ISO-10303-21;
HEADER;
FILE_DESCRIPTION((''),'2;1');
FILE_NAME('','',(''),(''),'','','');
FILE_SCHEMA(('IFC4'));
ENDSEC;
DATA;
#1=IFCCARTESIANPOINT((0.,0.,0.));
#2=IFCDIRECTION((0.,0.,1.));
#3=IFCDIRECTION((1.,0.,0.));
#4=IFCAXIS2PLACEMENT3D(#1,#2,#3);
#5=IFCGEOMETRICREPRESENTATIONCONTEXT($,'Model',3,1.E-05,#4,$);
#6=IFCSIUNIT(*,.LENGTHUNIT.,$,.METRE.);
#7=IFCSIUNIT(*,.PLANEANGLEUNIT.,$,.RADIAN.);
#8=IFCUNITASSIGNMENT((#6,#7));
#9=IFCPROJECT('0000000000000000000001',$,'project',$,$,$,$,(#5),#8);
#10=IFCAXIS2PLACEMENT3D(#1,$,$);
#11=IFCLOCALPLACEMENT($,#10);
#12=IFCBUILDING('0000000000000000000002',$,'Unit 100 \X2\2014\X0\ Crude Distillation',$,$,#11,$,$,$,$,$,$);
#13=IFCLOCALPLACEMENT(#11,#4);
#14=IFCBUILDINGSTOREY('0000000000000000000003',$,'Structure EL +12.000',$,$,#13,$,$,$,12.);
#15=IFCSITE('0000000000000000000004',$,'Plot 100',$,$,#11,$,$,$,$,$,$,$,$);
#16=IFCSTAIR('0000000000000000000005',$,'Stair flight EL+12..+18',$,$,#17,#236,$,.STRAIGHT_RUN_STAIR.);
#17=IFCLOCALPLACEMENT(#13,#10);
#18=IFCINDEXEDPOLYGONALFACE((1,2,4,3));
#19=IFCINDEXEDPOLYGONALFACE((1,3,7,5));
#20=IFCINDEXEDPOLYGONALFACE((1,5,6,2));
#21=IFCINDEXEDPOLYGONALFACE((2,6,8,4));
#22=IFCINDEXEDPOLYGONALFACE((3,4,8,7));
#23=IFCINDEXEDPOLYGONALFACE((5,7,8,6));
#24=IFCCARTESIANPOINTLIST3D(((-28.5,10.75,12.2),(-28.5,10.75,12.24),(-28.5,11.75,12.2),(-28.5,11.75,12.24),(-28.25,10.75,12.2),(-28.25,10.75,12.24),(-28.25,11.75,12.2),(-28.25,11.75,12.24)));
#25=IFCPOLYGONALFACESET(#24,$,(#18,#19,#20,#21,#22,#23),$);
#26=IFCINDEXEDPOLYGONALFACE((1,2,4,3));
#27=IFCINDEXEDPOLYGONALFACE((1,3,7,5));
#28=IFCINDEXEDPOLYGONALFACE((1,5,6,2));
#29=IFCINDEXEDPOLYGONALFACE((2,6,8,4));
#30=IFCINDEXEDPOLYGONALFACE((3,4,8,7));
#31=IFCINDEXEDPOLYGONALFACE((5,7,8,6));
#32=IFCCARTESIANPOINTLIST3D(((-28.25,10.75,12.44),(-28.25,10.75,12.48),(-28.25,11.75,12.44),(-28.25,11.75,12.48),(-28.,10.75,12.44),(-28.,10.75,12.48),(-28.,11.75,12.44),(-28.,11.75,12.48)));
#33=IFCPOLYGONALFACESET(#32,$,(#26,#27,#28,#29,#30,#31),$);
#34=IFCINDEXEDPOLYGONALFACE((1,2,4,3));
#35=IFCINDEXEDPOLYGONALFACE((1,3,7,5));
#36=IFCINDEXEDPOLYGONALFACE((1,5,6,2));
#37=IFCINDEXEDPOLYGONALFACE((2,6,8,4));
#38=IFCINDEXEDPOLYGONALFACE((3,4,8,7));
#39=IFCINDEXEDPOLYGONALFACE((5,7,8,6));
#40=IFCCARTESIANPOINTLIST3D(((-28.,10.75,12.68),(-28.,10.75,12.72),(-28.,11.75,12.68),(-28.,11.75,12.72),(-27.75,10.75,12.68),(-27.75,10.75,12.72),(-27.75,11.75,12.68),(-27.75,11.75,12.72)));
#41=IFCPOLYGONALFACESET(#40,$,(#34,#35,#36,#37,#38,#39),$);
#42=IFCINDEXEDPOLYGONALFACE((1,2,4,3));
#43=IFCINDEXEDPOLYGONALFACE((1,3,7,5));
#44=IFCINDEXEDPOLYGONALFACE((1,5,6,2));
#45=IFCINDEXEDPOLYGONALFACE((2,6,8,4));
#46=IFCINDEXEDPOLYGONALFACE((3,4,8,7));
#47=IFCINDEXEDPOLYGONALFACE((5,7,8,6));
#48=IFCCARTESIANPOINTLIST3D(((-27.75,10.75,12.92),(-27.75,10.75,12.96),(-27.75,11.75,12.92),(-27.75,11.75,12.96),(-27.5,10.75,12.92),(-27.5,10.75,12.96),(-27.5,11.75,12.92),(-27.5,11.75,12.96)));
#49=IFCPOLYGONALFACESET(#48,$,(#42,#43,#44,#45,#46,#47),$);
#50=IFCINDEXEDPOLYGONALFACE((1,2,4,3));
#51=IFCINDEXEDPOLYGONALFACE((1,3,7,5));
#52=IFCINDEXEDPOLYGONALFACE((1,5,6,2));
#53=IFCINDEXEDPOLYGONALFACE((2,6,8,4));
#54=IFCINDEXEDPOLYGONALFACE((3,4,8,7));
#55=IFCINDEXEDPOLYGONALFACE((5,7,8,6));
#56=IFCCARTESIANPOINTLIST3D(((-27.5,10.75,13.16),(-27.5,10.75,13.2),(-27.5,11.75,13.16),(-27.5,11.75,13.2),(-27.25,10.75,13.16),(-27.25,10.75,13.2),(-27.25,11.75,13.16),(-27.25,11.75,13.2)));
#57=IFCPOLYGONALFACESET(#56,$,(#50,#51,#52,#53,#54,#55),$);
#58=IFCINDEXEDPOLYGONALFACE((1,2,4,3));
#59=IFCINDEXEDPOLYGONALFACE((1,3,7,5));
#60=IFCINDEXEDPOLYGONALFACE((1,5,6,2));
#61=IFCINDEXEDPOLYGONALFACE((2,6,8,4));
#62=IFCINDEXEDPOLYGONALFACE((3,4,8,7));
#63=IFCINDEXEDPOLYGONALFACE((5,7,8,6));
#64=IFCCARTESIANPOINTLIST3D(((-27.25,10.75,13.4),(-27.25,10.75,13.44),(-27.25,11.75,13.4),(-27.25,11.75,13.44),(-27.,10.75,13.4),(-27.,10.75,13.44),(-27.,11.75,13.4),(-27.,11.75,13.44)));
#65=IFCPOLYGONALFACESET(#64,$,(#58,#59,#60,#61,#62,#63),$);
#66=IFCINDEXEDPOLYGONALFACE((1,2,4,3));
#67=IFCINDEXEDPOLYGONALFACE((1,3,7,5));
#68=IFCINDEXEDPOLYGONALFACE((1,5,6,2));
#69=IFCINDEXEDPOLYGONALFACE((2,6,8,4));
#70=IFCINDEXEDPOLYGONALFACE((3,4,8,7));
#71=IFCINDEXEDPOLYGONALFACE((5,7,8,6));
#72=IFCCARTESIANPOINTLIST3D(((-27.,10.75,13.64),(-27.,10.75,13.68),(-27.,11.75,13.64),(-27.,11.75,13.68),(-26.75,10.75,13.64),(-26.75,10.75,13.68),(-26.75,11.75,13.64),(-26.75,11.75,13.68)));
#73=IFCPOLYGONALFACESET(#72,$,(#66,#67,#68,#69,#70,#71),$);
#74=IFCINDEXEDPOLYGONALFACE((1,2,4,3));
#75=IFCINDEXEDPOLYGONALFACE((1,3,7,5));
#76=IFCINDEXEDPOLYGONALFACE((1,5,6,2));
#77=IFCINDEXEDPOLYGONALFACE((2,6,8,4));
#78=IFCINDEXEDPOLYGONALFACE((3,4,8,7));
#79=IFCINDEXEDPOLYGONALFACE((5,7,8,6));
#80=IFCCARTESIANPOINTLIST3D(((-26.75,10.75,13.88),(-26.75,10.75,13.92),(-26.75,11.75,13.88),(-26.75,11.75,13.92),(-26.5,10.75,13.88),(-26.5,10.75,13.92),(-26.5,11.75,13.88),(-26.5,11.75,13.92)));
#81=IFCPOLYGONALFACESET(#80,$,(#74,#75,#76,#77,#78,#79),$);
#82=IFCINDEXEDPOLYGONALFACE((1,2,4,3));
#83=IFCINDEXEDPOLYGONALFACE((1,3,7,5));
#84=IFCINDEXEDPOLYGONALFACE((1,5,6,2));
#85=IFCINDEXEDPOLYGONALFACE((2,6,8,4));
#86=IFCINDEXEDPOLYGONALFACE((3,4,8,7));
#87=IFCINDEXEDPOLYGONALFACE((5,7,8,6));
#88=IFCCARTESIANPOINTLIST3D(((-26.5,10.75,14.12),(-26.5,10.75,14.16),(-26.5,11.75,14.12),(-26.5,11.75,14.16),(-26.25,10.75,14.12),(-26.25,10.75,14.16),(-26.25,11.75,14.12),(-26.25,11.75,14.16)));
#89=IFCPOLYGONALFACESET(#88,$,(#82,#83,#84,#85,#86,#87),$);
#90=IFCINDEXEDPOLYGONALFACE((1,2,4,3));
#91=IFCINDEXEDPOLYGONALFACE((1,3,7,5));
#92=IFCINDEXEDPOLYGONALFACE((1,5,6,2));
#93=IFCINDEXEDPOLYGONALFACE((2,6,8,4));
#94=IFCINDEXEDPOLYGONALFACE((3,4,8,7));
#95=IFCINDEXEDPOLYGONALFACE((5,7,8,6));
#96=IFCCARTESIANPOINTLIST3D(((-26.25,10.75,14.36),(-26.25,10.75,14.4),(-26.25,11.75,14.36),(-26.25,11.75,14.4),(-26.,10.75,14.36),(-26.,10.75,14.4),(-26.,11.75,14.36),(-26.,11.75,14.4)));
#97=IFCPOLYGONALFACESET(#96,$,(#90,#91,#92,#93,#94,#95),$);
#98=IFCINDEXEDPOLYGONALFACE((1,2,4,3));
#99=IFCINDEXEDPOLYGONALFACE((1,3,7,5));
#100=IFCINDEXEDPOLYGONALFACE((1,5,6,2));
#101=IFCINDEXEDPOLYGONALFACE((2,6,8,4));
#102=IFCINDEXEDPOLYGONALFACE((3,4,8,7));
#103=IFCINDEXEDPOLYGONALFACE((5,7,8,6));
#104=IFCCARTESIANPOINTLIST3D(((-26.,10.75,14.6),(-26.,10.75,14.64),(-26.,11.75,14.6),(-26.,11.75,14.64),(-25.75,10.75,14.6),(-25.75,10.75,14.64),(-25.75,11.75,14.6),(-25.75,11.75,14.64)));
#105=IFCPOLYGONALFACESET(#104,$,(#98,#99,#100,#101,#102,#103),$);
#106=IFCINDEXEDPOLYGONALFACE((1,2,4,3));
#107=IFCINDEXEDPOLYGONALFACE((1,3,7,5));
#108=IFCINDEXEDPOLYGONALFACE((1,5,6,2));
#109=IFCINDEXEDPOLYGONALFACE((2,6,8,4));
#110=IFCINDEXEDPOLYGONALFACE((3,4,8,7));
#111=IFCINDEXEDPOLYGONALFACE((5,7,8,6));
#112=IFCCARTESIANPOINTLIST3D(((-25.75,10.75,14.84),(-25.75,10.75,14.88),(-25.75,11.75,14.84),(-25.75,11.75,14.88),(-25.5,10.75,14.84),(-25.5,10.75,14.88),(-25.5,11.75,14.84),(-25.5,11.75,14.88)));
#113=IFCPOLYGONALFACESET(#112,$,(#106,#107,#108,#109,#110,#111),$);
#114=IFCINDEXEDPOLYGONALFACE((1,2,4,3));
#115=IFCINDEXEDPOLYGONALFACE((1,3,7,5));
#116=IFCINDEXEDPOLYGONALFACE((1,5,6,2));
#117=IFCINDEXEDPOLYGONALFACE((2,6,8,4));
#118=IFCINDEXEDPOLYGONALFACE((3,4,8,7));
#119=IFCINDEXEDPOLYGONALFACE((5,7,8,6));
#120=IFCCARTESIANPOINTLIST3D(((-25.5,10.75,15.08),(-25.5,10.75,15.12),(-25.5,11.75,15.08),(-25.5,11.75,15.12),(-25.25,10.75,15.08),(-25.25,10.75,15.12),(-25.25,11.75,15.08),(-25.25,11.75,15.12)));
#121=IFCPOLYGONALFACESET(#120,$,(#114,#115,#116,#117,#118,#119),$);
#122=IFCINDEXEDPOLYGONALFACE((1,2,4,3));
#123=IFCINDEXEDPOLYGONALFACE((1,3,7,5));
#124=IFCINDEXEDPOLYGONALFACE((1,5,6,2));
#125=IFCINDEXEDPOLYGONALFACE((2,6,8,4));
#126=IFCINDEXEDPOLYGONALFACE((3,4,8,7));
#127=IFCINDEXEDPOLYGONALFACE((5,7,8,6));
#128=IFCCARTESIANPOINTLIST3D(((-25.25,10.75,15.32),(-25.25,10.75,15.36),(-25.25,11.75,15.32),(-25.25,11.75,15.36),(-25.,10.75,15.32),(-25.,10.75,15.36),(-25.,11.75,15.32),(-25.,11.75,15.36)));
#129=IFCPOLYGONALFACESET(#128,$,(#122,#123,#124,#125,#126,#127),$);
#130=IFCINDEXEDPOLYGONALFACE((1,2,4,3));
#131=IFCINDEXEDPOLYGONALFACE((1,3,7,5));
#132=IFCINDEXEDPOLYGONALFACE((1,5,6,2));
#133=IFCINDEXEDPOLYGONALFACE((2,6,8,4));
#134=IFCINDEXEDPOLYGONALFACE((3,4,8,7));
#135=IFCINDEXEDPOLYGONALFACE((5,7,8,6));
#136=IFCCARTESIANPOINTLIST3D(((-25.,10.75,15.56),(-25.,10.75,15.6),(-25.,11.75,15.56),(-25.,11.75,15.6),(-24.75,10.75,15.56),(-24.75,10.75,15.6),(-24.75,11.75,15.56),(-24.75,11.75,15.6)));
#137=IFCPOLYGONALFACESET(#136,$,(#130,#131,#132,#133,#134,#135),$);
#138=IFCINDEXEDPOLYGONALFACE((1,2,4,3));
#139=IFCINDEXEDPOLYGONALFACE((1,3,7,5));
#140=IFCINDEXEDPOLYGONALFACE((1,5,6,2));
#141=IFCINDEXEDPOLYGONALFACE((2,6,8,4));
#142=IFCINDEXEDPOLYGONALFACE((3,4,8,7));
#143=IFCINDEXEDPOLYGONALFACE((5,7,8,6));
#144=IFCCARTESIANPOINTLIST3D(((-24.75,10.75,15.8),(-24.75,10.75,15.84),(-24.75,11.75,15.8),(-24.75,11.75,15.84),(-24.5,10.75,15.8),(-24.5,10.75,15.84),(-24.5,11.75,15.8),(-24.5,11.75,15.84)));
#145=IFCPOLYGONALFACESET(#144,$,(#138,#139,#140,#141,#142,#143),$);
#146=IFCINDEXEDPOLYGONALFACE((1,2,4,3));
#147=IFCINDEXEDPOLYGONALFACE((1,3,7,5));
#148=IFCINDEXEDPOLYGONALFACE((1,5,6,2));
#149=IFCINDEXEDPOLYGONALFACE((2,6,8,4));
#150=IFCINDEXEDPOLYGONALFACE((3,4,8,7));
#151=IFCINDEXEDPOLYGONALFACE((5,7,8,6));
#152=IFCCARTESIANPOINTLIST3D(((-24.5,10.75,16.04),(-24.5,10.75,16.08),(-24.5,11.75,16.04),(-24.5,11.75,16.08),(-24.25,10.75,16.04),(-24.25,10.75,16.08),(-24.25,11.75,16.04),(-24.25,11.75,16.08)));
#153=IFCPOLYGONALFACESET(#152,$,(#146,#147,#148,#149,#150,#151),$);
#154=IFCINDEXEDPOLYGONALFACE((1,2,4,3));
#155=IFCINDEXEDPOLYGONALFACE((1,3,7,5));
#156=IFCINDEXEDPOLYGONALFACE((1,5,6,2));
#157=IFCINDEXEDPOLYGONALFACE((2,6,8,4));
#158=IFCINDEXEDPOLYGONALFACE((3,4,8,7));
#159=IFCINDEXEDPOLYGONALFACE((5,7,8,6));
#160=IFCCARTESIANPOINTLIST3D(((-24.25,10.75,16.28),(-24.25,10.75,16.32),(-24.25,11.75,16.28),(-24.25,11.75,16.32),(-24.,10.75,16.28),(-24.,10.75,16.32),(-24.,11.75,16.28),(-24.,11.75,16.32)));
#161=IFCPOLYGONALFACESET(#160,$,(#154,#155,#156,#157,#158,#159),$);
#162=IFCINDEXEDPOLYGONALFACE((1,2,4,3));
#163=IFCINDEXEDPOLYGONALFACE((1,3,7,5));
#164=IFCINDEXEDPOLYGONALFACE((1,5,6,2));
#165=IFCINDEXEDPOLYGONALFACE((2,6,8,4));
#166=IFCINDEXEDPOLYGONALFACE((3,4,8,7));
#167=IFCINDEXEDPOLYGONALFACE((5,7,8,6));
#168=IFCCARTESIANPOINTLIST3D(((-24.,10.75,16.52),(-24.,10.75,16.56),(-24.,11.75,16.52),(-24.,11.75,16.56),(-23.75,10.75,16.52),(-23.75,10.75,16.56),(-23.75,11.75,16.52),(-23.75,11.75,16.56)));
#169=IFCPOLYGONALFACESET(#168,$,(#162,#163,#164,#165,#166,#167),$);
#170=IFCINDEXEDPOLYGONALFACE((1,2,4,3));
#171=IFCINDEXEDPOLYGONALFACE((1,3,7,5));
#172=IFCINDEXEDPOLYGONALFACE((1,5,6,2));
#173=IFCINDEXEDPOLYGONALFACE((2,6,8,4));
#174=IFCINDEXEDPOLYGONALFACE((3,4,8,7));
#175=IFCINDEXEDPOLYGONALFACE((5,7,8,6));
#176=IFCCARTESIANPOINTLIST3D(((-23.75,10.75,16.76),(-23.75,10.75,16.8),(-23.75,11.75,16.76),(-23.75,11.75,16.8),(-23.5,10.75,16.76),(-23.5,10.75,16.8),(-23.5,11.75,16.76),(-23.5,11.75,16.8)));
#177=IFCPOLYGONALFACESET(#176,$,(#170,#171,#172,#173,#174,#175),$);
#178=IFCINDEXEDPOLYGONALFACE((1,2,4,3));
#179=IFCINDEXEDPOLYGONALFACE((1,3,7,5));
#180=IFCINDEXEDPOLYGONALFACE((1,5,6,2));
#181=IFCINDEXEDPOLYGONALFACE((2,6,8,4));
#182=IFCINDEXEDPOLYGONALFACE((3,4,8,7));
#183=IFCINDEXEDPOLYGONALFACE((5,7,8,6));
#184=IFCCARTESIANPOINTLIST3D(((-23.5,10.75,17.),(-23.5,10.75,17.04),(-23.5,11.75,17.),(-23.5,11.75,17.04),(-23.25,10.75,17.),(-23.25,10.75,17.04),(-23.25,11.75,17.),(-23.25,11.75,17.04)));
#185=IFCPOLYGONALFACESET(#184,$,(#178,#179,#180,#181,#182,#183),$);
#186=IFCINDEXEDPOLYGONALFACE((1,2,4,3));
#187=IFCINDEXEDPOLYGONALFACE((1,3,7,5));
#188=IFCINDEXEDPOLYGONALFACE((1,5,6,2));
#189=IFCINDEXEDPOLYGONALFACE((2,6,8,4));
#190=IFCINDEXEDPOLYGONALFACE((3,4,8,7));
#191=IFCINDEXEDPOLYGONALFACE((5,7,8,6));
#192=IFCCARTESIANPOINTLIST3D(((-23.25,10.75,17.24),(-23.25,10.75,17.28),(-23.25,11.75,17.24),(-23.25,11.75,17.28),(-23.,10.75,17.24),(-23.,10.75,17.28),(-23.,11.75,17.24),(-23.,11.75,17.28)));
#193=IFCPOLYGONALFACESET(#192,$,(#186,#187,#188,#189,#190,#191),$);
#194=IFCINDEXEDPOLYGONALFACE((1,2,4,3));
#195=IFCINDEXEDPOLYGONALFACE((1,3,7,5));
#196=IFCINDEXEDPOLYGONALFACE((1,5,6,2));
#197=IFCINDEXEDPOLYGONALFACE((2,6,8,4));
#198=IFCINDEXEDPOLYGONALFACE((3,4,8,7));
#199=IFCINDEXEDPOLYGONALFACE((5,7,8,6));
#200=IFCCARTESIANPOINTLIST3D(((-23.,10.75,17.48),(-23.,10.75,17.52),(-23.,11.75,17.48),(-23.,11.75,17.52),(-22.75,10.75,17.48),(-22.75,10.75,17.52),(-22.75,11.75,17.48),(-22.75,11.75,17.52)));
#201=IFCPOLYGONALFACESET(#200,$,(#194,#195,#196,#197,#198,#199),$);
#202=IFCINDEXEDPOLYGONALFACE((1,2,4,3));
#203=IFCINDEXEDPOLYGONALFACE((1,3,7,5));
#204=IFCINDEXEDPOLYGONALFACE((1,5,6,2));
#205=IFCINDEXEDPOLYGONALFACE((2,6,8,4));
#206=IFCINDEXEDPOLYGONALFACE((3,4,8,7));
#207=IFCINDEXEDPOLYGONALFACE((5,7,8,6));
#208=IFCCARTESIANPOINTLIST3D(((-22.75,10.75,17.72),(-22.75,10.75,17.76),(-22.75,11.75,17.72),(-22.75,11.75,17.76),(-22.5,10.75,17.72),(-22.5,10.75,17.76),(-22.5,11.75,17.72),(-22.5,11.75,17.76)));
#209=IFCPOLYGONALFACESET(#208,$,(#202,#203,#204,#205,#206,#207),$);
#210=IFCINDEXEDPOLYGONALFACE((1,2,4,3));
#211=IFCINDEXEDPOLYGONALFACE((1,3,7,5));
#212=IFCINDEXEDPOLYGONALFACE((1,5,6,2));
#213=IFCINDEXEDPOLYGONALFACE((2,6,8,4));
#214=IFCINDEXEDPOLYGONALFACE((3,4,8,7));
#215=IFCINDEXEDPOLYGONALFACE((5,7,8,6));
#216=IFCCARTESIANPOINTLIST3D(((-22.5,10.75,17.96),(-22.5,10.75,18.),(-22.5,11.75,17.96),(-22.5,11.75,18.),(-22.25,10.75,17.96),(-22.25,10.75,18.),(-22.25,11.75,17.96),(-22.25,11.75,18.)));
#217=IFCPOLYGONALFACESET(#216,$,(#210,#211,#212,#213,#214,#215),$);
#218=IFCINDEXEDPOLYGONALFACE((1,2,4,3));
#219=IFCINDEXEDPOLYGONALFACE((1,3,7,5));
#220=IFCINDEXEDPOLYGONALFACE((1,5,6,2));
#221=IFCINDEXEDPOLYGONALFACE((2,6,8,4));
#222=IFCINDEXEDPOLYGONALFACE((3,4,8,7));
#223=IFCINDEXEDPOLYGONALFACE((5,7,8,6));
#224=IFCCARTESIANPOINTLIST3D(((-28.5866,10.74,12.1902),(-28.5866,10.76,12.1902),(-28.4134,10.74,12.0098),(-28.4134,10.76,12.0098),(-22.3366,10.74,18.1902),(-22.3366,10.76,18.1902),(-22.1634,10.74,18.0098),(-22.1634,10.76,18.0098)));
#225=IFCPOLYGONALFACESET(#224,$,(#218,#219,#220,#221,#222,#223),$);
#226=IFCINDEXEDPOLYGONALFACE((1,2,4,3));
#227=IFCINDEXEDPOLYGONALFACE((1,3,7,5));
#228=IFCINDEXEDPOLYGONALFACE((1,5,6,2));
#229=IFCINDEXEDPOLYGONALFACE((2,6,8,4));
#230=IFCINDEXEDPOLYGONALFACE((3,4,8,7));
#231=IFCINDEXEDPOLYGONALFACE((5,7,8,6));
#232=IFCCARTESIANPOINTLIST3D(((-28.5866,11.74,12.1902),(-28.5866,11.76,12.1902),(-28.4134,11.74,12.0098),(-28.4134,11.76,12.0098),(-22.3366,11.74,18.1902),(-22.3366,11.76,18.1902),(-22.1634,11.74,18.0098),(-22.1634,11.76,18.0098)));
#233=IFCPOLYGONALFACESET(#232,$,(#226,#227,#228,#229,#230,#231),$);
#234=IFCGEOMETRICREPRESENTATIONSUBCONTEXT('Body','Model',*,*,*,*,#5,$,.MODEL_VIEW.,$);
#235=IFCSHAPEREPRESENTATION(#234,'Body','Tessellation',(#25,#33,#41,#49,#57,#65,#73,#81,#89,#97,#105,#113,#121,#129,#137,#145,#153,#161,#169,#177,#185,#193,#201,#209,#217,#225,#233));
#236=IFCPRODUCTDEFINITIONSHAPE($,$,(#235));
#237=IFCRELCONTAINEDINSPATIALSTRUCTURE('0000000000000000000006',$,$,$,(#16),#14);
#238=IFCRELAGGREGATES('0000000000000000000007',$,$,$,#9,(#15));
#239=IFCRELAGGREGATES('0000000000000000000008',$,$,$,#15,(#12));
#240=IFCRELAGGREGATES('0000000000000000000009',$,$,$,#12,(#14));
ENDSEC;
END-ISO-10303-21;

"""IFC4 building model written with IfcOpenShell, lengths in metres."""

from ifc_helpers import new_model, si_unit, frame, origin, origin_with_axes, origin_2d, place, context, subcontext, project, spatial, rectangle, extrude, element, save


model = new_model("IFC4")

# Units and contexts
model_context = context("Model", 3, precision=1e-05, world=origin_with_axes())
body_context = subcontext(model_context, "Body", "Model", "MODEL_VIEW")
ifc_project = project(units=[si_unit("LENGTHUNIT", "METRE"), si_unit("PLANEANGLEUNIT", "RADIAN")], contexts=[model_context])

# Site, building, storey
placement = place(None, origin())
site = spatial("IfcSite", under=ifc_project, at=placement, Name="Plot 100")
building = spatial("IfcBuilding", under=site, at=placement, Name="Unit 100 — Crude Distillation")
storey_placement = place(placement, origin_with_axes())
storey = spatial("IfcBuildingStorey", under=building, at=storey_placement, Name="Structure EL +12.000", Elevation=12.0)

# Stair
stair_placement = place(storey_placement, origin_with_axes())
element("IfcStair", 1, at=stair_placement, inside=storey, Name="Stair flight EL+12..+18", PredefinedType="STRAIGHT_RUN_STAIR", context=body_context, shape_type="SweptSolid", body=[
    extrude(rectangle(XDim=0.25, YDim=1.0, at=origin_2d()), frame((-28.375, 11.25, 12.2), z_axis=(0.0, 0.0, 1.0), x_axis=(1.0, 0.0, 0.0)), (0.0, 0.0, 1.0), 0.04),
    extrude(rectangle(XDim=0.25, YDim=1.0, at=origin_2d()), frame((-28.125, 11.25, 12.44), z_axis=(0.0, 0.0, 1.0), x_axis=(1.0, 0.0, 0.0)), (0.0, 0.0, 1.0), 0.04),
    extrude(rectangle(XDim=0.25, YDim=1.0, at=origin_2d()), frame((-27.875, 11.25, 12.68), z_axis=(0.0, 0.0, 1.0), x_axis=(1.0, 0.0, 0.0)), (0.0, 0.0, 1.0), 0.04),
    extrude(rectangle(XDim=0.25, YDim=1.0, at=origin_2d()), frame((-27.625, 11.25, 12.92), z_axis=(0.0, 0.0, 1.0), x_axis=(1.0, 0.0, 0.0)), (0.0, 0.0, 1.0), 0.04),
    extrude(rectangle(XDim=0.25, YDim=1.0, at=origin_2d()), frame((-27.375, 11.25, 13.16), z_axis=(0.0, 0.0, 1.0), x_axis=(1.0, 0.0, 0.0)), (0.0, 0.0, 1.0), 0.04),
    extrude(rectangle(XDim=0.25, YDim=1.0, at=origin_2d()), frame((-27.125, 11.25, 13.4), z_axis=(0.0, 0.0, 1.0), x_axis=(1.0, 0.0, 0.0)), (0.0, 0.0, 1.0), 0.04),
    extrude(rectangle(XDim=0.25, YDim=1.0, at=origin_2d()), frame((-26.875, 11.25, 13.64), z_axis=(0.0, 0.0, 1.0), x_axis=(1.0, 0.0, 0.0)), (0.0, 0.0, 1.0), 0.04),
    extrude(rectangle(XDim=0.25, YDim=1.0, at=origin_2d()), frame((-26.625, 11.25, 13.88), z_axis=(0.0, 0.0, 1.0), x_axis=(1.0, 0.0, 0.0)), (0.0, 0.0, 1.0), 0.04),
    extrude(rectangle(XDim=0.25, YDim=1.0, at=origin_2d()), frame((-26.375, 11.25, 14.12), z_axis=(0.0, 0.0, 1.0), x_axis=(1.0, 0.0, 0.0)), (0.0, 0.0, 1.0), 0.04),
    extrude(rectangle(XDim=0.25, YDim=1.0, at=origin_2d()), frame((-26.125, 11.25, 14.36), z_axis=(0.0, 0.0, 1.0), x_axis=(1.0, 0.0, 0.0)), (0.0, 0.0, 1.0), 0.04),
    extrude(rectangle(XDim=0.25, YDim=1.0, at=origin_2d()), frame((-25.875, 11.25, 14.6), z_axis=(0.0, 0.0, 1.0), x_axis=(1.0, 0.0, 0.0)), (0.0, 0.0, 1.0), 0.04),
    extrude(rectangle(XDim=0.25, YDim=1.0, at=origin_2d()), frame((-25.625, 11.25, 14.84), z_axis=(0.0, 0.0, 1.0), x_axis=(1.0, 0.0, 0.0)), (0.0, 0.0, 1.0), 0.04),
    extrude(rectangle(XDim=0.25, YDim=1.0, at=origin_2d()), frame((-25.375, 11.25, 15.08), z_axis=(0.0, 0.0, 1.0), x_axis=(1.0, 0.0, 0.0)), (0.0, 0.0, 1.0), 0.04),
    extrude(rectangle(XDim=0.25, YDim=1.0, at=origin_2d()), frame((-25.125, 11.25, 15.32), z_axis=(0.0, 0.0, 1.0), x_axis=(1.0, 0.0, 0.0)), (0.0, 0.0, 1.0), 0.04),
    extrude(rectangle(XDim=0.25, YDim=1.0, at=origin_2d()), frame((-24.875, 11.25, 15.56), z_axis=(0.0, 0.0, 1.0), x_axis=(1.0, 0.0, 0.0)), (0.0, 0.0, 1.0), 0.04),
    extrude(rectangle(XDim=0.25, YDim=1.0, at=origin_2d()), frame((-24.625, 11.25, 15.8), z_axis=(0.0, 0.0, 1.0), x_axis=(1.0, 0.0, 0.0)), (0.0, 0.0, 1.0), 0.04),
    extrude(rectangle(XDim=0.25, YDim=1.0, at=origin_2d()), frame((-24.375, 11.25, 16.04), z_axis=(0.0, 0.0, 1.0), x_axis=(1.0, 0.0, 0.0)), (0.0, 0.0, 1.0), 0.04),
    extrude(rectangle(XDim=0.25, YDim=1.0, at=origin_2d()), frame((-24.125, 11.25, 16.28), z_axis=(0.0, 0.0, 1.0), x_axis=(1.0, 0.0, 0.0)), (0.0, 0.0, 1.0), 0.04),
    extrude(rectangle(XDim=0.25, YDim=1.0, at=origin_2d()), frame((-23.875, 11.25, 16.52), z_axis=(0.0, 0.0, 1.0), x_axis=(1.0, 0.0, 0.0)), (0.0, 0.0, 1.0), 0.04),
    extrude(rectangle(XDim=0.25, YDim=1.0, at=origin_2d()), frame((-23.625, 11.25, 16.76), z_axis=(0.0, 0.0, 1.0), x_axis=(1.0, 0.0, 0.0)), (0.0, 0.0, 1.0), 0.04),
    extrude(rectangle(XDim=0.25, YDim=1.0, at=origin_2d()), frame((-23.375, 11.25, 17.0), z_axis=(0.0, 0.0, 1.0), x_axis=(1.0, 0.0, 0.0)), (0.0, 0.0, 1.0), 0.04),
    extrude(rectangle(XDim=0.25, YDim=1.0, at=origin_2d()), frame((-23.125, 11.25, 17.24), z_axis=(0.0, 0.0, 1.0), x_axis=(1.0, 0.0, 0.0)), (0.0, 0.0, 1.0), 0.04),
    extrude(rectangle(XDim=0.25, YDim=1.0, at=origin_2d()), frame((-22.875, 11.25, 17.48), z_axis=(0.0, 0.0, 1.0), x_axis=(1.0, 0.0, 0.0)), (0.0, 0.0, 1.0), 0.04),
    extrude(rectangle(XDim=0.25, YDim=1.0, at=origin_2d()), frame((-22.625, 11.25, 17.72), z_axis=(0.0, 0.0, 1.0), x_axis=(1.0, 0.0, 0.0)), (0.0, 0.0, 1.0), 0.04),
    extrude(rectangle(XDim=0.25, YDim=1.0, at=origin_2d()), frame((-22.375, 11.25, 17.96), z_axis=(0.0, 0.0, 1.0), x_axis=(1.0, 0.0, 0.0)), (0.0, 0.0, 1.0), 0.04),
    extrude(rectangle(XDim=0.02, YDim=0.25, at=origin_2d()), frame((-28.5, 10.75, 12.1), z_axis=(0.721387, 0.0, 0.692532), x_axis=(0.0, 1.0, 0.0)), (0.0, 0.0, 1.0), 8.6639),
    extrude(rectangle(XDim=0.02, YDim=0.25, at=origin_2d()), frame((-28.5, 11.75, 12.1), z_axis=(0.721387, 0.0, 0.692532), x_axis=(0.0, 1.0, 0.0)), (0.0, 0.0, 1.0), 8.6639),
])

save(model, "model.ifc")
